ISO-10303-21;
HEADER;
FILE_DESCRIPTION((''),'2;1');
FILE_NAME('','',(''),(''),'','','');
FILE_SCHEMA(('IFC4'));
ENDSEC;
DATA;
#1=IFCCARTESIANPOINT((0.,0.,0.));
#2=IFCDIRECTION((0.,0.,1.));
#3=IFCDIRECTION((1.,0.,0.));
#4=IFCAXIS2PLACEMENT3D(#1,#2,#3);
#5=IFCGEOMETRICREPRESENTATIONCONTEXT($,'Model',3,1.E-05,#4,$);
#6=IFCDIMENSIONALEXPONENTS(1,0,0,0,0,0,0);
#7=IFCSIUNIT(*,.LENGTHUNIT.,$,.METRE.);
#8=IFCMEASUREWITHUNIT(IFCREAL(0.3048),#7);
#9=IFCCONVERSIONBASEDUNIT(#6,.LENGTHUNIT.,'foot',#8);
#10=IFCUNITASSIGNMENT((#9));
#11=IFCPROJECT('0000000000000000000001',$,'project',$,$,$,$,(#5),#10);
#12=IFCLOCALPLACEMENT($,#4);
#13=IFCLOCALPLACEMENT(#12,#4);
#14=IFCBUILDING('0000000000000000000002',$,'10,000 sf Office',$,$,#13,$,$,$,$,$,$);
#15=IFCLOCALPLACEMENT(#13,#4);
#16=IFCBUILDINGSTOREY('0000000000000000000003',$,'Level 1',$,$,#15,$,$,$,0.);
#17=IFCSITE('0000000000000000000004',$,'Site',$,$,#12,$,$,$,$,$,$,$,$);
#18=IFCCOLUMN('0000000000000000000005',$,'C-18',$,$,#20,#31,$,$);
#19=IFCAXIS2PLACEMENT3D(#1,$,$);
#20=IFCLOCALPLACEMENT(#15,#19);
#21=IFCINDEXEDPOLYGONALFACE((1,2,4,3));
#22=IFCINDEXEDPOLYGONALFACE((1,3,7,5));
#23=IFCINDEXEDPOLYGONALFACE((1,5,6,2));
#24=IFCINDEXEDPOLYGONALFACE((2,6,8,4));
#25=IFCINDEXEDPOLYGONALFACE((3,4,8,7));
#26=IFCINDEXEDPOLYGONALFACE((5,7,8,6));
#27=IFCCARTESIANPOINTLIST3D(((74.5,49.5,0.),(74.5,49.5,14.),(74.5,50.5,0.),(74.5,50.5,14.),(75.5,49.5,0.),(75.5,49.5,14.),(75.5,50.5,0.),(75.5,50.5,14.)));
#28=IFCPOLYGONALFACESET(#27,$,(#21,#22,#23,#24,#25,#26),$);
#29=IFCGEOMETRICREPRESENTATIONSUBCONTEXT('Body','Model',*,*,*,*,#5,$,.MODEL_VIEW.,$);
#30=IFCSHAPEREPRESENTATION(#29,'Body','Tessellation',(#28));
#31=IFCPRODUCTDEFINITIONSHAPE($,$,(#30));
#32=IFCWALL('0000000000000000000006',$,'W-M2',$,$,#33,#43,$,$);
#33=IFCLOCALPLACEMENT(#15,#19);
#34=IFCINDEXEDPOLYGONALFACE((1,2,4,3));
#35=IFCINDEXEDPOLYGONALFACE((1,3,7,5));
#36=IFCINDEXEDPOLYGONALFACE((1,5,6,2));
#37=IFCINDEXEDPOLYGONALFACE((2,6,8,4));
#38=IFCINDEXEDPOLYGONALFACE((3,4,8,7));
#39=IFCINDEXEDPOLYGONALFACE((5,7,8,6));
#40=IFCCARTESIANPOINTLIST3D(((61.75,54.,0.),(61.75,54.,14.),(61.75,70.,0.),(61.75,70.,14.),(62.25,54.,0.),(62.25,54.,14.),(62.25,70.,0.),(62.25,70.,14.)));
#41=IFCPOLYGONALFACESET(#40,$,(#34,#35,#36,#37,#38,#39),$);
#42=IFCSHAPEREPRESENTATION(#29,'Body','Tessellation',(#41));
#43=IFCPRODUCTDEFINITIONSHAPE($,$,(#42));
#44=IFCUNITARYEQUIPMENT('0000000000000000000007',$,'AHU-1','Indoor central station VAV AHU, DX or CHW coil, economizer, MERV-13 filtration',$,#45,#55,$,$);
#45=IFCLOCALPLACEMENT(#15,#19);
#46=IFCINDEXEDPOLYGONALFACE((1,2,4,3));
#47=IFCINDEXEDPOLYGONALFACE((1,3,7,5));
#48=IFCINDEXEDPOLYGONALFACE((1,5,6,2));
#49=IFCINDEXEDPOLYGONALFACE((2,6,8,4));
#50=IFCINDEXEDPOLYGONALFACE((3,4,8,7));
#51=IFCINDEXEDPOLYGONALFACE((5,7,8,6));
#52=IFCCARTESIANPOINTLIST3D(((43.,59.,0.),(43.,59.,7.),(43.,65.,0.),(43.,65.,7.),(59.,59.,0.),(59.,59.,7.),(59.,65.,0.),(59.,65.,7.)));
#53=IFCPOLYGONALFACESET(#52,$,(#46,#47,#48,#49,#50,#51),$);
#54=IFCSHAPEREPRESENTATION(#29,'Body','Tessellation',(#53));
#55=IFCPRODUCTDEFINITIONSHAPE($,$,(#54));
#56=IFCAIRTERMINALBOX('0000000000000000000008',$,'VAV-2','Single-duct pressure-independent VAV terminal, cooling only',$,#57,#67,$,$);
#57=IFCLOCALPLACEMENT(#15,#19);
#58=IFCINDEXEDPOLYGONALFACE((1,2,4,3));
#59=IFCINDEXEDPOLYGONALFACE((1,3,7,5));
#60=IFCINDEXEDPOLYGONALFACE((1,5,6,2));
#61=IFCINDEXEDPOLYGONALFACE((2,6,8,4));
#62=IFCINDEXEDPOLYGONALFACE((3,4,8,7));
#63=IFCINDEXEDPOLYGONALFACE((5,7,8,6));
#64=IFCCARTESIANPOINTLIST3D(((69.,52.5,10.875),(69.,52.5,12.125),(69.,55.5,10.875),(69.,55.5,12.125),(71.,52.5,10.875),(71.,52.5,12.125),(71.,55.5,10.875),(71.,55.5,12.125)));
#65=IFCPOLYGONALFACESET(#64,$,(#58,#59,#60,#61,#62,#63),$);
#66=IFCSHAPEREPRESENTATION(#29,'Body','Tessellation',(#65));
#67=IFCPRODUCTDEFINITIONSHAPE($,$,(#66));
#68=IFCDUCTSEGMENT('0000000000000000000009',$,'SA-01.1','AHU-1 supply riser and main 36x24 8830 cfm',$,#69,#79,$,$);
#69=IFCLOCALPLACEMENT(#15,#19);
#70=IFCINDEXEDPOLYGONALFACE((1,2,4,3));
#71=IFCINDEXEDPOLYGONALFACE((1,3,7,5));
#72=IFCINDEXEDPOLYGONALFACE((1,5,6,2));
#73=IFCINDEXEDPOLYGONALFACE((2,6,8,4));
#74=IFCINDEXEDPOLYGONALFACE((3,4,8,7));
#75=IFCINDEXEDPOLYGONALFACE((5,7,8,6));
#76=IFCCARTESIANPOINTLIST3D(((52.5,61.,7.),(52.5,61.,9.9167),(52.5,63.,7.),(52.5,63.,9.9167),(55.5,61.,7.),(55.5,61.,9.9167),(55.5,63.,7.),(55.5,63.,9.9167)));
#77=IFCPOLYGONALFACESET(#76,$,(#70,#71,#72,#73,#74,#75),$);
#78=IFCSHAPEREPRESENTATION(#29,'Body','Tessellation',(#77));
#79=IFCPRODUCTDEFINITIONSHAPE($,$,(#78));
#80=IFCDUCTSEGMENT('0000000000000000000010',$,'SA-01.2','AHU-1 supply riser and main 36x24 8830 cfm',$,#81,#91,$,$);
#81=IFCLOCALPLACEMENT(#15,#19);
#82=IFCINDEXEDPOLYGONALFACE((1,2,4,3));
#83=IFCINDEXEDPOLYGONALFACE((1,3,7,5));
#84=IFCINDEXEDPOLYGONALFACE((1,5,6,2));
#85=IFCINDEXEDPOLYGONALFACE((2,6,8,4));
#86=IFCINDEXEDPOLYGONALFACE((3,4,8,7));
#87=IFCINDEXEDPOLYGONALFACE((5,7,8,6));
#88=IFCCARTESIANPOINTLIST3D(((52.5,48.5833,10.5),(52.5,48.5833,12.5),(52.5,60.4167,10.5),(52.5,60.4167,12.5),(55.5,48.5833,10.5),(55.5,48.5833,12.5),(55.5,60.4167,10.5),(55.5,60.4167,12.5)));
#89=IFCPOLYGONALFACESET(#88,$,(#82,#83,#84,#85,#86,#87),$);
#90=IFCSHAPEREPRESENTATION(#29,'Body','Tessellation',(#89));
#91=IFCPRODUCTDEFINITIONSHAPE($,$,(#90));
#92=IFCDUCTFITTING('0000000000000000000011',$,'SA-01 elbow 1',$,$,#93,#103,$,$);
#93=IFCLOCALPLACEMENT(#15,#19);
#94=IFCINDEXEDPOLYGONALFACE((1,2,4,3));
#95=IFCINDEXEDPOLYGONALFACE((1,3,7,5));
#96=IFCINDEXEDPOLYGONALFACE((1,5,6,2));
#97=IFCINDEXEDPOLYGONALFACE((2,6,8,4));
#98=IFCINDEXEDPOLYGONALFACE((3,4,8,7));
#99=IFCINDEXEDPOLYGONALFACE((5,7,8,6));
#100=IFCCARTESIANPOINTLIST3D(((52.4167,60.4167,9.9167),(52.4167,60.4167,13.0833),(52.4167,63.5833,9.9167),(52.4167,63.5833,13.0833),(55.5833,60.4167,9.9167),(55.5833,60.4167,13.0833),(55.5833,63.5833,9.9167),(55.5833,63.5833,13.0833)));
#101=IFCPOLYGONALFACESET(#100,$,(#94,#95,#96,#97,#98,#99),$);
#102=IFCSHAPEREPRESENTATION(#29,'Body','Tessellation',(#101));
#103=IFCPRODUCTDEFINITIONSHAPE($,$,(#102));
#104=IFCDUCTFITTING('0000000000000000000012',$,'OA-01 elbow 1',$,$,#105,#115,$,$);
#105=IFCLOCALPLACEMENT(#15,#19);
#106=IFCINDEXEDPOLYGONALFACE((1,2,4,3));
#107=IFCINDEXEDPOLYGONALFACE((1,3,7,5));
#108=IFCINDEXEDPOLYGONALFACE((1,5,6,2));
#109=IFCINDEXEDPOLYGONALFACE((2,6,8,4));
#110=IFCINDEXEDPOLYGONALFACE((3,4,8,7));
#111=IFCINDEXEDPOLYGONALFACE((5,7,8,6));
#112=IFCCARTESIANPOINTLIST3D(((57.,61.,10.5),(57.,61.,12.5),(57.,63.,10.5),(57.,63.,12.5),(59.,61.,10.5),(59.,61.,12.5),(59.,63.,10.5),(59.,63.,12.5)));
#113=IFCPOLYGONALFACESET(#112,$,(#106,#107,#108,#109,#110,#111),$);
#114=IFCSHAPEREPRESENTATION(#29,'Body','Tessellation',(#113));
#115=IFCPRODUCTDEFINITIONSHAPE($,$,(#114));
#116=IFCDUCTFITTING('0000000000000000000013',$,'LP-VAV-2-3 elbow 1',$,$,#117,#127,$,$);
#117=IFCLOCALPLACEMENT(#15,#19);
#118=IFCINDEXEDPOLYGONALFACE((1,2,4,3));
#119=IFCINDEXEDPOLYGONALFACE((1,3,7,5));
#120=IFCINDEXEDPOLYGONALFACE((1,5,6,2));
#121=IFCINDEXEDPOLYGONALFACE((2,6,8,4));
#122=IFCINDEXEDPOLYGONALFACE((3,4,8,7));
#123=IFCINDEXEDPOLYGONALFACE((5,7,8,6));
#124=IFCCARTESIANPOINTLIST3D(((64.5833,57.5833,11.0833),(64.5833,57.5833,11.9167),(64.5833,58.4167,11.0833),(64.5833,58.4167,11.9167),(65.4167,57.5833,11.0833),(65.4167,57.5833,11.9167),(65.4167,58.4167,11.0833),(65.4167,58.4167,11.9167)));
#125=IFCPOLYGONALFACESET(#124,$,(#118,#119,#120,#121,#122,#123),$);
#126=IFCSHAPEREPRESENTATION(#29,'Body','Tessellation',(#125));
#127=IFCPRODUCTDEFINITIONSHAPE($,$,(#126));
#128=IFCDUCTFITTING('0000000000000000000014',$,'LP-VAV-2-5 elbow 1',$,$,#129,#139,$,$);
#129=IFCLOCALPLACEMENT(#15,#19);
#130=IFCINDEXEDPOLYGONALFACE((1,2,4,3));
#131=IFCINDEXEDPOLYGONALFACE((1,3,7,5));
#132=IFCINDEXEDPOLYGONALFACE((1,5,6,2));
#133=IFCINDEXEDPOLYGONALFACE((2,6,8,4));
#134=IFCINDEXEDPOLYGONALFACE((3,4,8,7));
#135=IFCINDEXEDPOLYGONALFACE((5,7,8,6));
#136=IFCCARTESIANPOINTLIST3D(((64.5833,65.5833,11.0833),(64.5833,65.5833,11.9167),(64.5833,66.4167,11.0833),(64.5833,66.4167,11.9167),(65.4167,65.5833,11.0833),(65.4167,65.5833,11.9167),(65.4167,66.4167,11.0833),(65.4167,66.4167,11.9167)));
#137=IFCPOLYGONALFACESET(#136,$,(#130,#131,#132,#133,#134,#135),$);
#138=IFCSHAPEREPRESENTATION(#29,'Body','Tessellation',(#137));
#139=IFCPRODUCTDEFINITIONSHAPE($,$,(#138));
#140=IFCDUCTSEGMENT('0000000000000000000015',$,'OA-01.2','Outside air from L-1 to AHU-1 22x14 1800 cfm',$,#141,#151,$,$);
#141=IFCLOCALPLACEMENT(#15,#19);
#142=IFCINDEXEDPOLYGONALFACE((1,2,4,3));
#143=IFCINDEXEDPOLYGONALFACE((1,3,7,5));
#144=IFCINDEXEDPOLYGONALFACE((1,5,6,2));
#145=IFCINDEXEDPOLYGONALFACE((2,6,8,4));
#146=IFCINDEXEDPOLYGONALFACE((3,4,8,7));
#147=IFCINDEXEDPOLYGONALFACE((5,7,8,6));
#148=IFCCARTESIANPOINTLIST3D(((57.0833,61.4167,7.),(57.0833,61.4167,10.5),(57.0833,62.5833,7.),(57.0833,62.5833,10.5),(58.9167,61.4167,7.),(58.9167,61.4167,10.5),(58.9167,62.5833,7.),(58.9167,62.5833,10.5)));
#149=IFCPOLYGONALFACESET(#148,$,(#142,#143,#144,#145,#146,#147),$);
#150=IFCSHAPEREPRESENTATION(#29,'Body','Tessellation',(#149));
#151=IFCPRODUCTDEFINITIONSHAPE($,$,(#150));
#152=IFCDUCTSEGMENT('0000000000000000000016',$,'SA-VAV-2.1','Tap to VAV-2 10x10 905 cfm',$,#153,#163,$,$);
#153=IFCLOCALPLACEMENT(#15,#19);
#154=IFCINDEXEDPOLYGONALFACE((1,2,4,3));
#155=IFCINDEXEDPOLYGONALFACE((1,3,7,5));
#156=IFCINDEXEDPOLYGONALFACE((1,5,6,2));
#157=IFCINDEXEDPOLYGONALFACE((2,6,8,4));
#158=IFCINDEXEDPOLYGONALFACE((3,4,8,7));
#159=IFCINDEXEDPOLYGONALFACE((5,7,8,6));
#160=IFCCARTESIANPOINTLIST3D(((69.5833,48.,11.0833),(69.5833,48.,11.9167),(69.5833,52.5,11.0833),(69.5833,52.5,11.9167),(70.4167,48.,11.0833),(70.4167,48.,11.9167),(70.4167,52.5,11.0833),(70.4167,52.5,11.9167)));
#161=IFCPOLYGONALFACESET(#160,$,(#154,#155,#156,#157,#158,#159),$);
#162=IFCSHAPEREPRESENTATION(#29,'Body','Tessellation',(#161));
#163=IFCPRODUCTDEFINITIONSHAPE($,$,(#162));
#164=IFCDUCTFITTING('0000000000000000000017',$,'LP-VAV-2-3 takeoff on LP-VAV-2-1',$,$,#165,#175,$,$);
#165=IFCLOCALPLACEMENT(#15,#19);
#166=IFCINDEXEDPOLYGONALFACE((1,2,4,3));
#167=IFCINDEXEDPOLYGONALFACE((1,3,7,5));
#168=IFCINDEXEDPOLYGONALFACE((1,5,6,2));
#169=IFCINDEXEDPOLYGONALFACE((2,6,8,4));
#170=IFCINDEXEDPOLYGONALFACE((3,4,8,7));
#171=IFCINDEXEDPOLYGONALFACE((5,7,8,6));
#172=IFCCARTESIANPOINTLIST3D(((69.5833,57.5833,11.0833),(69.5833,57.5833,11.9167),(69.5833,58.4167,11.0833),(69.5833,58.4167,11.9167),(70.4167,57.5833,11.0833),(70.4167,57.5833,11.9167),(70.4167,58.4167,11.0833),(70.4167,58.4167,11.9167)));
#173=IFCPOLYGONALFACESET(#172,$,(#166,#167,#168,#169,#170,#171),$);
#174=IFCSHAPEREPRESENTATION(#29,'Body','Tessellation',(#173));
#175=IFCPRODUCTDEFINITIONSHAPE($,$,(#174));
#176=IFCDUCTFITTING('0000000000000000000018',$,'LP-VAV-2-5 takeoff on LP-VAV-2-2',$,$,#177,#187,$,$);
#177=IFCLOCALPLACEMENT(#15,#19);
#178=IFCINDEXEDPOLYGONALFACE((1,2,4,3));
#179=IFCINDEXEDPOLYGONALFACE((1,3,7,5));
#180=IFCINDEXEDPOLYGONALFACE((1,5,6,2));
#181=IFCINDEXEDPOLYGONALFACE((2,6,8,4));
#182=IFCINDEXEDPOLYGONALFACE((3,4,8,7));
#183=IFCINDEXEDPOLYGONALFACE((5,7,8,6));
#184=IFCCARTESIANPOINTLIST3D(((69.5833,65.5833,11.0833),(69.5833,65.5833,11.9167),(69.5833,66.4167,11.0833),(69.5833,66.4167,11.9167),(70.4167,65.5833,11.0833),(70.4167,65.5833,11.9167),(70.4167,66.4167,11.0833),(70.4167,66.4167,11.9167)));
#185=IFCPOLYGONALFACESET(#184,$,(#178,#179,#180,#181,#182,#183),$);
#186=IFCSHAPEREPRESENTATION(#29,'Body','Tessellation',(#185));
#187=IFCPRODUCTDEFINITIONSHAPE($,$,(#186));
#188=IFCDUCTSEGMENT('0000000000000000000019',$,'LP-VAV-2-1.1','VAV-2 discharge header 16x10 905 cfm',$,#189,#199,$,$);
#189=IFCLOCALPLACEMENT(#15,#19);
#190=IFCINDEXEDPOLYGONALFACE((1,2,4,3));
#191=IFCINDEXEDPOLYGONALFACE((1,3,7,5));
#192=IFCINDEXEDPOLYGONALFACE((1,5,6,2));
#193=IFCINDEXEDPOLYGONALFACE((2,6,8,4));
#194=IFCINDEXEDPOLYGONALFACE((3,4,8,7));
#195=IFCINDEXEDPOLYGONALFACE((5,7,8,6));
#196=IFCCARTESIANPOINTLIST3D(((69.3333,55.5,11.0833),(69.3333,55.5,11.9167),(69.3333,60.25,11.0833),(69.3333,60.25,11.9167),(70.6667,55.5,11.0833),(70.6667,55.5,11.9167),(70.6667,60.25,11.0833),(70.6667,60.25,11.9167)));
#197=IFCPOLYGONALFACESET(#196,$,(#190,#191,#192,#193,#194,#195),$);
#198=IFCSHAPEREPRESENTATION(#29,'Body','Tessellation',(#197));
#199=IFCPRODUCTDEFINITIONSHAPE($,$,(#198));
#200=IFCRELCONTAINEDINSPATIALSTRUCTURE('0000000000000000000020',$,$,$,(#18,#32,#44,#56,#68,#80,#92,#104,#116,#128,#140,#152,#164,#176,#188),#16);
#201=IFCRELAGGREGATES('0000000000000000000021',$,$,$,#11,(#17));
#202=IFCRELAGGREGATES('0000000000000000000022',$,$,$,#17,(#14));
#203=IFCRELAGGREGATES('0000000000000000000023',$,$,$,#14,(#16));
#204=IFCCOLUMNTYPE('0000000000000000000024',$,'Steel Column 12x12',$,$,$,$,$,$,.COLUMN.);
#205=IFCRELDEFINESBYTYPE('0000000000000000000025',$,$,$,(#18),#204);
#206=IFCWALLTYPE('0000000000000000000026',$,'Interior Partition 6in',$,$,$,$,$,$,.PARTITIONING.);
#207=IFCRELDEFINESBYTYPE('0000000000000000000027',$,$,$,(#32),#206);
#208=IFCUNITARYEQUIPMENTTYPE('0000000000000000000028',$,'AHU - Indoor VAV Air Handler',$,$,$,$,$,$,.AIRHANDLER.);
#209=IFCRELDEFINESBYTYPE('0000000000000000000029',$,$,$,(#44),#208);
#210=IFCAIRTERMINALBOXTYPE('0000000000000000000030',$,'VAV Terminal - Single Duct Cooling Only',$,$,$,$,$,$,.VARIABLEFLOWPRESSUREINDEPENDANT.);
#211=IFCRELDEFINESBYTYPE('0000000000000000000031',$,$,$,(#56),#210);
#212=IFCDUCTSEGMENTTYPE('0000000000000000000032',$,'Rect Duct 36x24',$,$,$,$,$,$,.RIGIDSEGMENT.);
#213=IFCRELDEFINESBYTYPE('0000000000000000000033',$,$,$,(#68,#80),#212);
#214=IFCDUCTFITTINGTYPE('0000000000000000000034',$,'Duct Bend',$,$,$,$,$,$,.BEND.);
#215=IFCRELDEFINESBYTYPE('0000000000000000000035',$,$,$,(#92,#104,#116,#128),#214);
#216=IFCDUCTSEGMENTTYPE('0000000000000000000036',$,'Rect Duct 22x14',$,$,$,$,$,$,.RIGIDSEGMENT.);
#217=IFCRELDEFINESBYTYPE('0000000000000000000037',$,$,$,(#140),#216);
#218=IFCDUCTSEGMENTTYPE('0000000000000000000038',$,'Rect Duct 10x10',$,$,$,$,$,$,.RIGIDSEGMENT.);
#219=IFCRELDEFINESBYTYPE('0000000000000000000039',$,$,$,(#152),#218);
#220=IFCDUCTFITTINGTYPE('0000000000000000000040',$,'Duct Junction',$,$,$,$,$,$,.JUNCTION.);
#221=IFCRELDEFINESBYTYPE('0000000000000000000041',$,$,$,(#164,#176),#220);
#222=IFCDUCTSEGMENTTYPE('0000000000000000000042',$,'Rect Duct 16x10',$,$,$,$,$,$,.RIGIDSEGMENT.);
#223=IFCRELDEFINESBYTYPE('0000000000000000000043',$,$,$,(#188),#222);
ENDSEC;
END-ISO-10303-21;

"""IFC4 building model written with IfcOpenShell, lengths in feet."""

from ifc_helpers import new_model, entity, si_unit, converted_unit, frame, origin_with_axes, place, context, subcontext, project, spatial, rectangle, extrude, type_object, element, save


model = new_model("IFC4")

# Units and contexts
model_context = context("Model", 3, precision=1e-05, world=origin_with_axes())
body_context = subcontext(model_context, "Body", "Model", "MODEL_VIEW")
ifc_project = project(units=[converted_unit("LENGTHUNIT", "foot", entity("IfcReal", 0.3048), si_unit("LENGTHUNIT", "METRE"), dimensions=[1, 0, 0, 0, 0, 0, 0])], contexts=[model_context])

# Site, building, storey
site_placement = place(None, origin_with_axes())
site = spatial("IfcSite", under=ifc_project, at=site_placement, Name="Site")
building_placement = place(site_placement, origin_with_axes())
building = spatial("IfcBuilding", under=site, at=building_placement, Name="10,000 sf Office")
storey_placement = place(building_placement, origin_with_axes())
storey = spatial("IfcBuildingStorey", under=building, at=storey_placement, Name="Level 1", Elevation=0.0)

# Column
column_type = type_object("IfcColumnType", Name="Steel Column 12x12", PredefinedType="COLUMN")
column_placement = place(storey_placement, frame((75.0, 50.0, 0.0), z_axis=(0.0, 0.0, 1.0), x_axis=(1.0, 0.0, 0.0)))
element("IfcColumn", 1, at=column_placement, inside=storey, type_object=column_type, Name="C-18", context=body_context, shape_type="SweptSolid", body=[
    extrude(rectangle(XDim=1.0, YDim=1.0), None, (0.0, 0.0, 1.0), 14.0),
])

# Wall
wall_type = type_object("IfcWallType", Name="Interior Partition 6in", PredefinedType="PARTITIONING")
wall_placement = place(storey_placement, frame((62.0, 62.0, 0.0), z_axis=(0.0, 0.0, 1.0), x_axis=(0.0, 1.0, 0.0)))
element("IfcWall", 2, at=wall_placement, inside=storey, type_object=wall_type, Name="W-M2", context=body_context, shape_type="SweptSolid", body=[
    extrude(rectangle(XDim=16.0, YDim=0.5), None, (0.0, 0.0, 1.0), 14.0),
])

# Unitary equipment
unitary_equipment_type = type_object("IfcUnitaryEquipmentType", Name="AHU - Indoor VAV Air Handler", PredefinedType="AIRHANDLER")
unitary_equipment_placement = place(storey_placement, frame((51.0, 62.0, 0.0), z_axis=(0.0, 0.0, 1.0), x_axis=(1.0, 0.0, 0.0)))
element("IfcUnitaryEquipment", 3, at=unitary_equipment_placement, inside=storey, type_object=unitary_equipment_type, Name="AHU-1", Description="Indoor central station VAV AHU, DX or CHW coil, economizer, MERV-13 filtration", context=body_context, shape_type="SweptSolid", body=[
    extrude(rectangle(XDim=16.0, YDim=6.0), None, (0.0, 0.0, 1.0), 7.0),
])

# Air terminal box
air_terminal_box_type = type_object("IfcAirTerminalBoxType", Name="VAV Terminal - Single Duct Cooling Only", PredefinedType="VARIABLEFLOWPRESSUREINDEPENDANT")
air_terminal_box_placement = place(storey_placement, frame((70.0, 54.0, 10.875), z_axis=(0.0, 0.0, 1.0), x_axis=(0.0, 1.0, 0.0)))
element("IfcAirTerminalBox", 4, at=air_terminal_box_placement, inside=storey, type_object=air_terminal_box_type, Name="VAV-2", Description="Single-duct pressure-independent VAV terminal, cooling only", context=body_context, shape_type="SweptSolid", body=[
    extrude(rectangle(XDim=3.0, YDim=2.0), None, (0.0, 0.0, 1.0), 1.25),
])

# Duct segments
duct_segment_type_1 = type_object("IfcDuctSegmentType", Name="Rect Duct 36x24", PredefinedType="RIGIDSEGMENT")
duct_segment_1_placement = place(storey_placement, frame((54.0, 62.0, 7.0), z_axis=(0.0, 0.0, 1.0), x_axis=(1.0, 0.0, 0.0)))
element("IfcDuctSegment", 5, at=duct_segment_1_placement, inside=storey, type_object=duct_segment_type_1, Name="SA-01.1", Description="AHU-1 supply riser and main 36x24 8830 cfm", context=body_context, shape_type="SweptSolid", body=[
    extrude(rectangle(XDim=3.0, YDim=2.0), None, (0.0, 0.0, 1.0), 2.9167),
])
duct_segment_2_placement = place(storey_placement, frame((54.0, 60.4167, 11.5), z_axis=(0.0, -1.0, 0.0), x_axis=(1.0, 0.0, 0.0)))
element("IfcDuctSegment", 6, at=duct_segment_2_placement, inside=storey, type_object=duct_segment_type_1, Name="SA-01.2", Description="AHU-1 supply riser and main 36x24 8830 cfm", context=body_context, shape_type="SweptSolid", body=[
    extrude(rectangle(XDim=3.0, YDim=2.0), None, (0.0, 0.0, 1.0), 11.8333),
])

# Duct fittings
duct_fitting_type_1 = type_object("IfcDuctFittingType", Name="Duct Bend", PredefinedType="BEND")
duct_fitting_1_placement = place(storey_placement, frame((54.0, 62.0, 9.9167), z_axis=(0.0, 0.0, 1.0), x_axis=(1.0, 0.0, 0.0)))
element("IfcDuctFitting", 7, at=duct_fitting_1_placement, inside=storey, type_object=duct_fitting_type_1, Name="SA-01 elbow 1", context=body_context, shape_type="SweptSolid", body=[
    extrude(rectangle(XDim=3.1667, YDim=3.1667), None, (0.0, 0.0, 1.0), 3.1667),
])
duct_fitting_2_placement = place(storey_placement, frame((58.0, 62.0, 10.5), z_axis=(0.0, 0.0, 1.0), x_axis=(1.0, 0.0, 0.0)))
element("IfcDuctFitting", 8, at=duct_fitting_2_placement, inside=storey, type_object=duct_fitting_type_1, Name="OA-01 elbow 1", context=body_context, shape_type="SweptSolid", body=[
    extrude(rectangle(XDim=2.0, YDim=2.0), None, (0.0, 0.0, 1.0), 2.0),
])
for number, where, z_axis, x_axis, name in (
    (9, (65.0, 58.0, 11.0833), (0.0, 0.0, 1.0), (1.0, 0.0, 0.0), "LP-VAV-2-3 elbow 1"),
    (10, (65.0, 66.0, 11.0833), (0.0, 0.0, 1.0), (1.0, 0.0, 0.0), "LP-VAV-2-5 elbow 1"),
):
    element("IfcDuctFitting", number, at=place(storey_placement, frame(where, z_axis=z_axis, x_axis=x_axis)), inside=storey, type_object=duct_fitting_type_1, Name=name, context=body_context, shape_type="SweptSolid", body=[
        extrude(rectangle(XDim=0.8333, YDim=0.8333), None, (0.0, 0.0, 1.0), 0.8333),
    ])

# Duct segments
duct_segment_type_2 = type_object("IfcDuctSegmentType", Name="Rect Duct 22x14", PredefinedType="RIGIDSEGMENT")
duct_segment_3_placement = place(storey_placement, frame((58.0, 62.0, 10.5), z_axis=(0.0, 0.0, -1.0), x_axis=(1.0, 0.0, 0.0)))
element("IfcDuctSegment", 11, at=duct_segment_3_placement, inside=storey, type_object=duct_segment_type_2, Name="OA-01.2", Description="Outside air from L-1 to AHU-1 22x14 1800 cfm", context=body_context, shape_type="SweptSolid", body=[
    extrude(rectangle(XDim=1.8333, YDim=1.1667), None, (0.0, 0.0, 1.0), 3.5),
])
duct_segment_type_3 = type_object("IfcDuctSegmentType", Name="Rect Duct 10x10", PredefinedType="RIGIDSEGMENT")
duct_segment_4_placement = place(storey_placement, frame((70.0, 48.0, 11.5), z_axis=(0.0, 1.0, 0.0), x_axis=(-1.0, 0.0, 0.0)))
element("IfcDuctSegment", 12, at=duct_segment_4_placement, inside=storey, type_object=duct_segment_type_3, Name="SA-VAV-2.1", Description="Tap to VAV-2 10x10 905 cfm", context=body_context, shape_type="SweptSolid", body=[
    extrude(rectangle(XDim=0.8333, YDim=0.8333), None, (0.0, 0.0, 1.0), 4.5),
])

# Duct fittings
duct_fitting_type_2 = type_object("IfcDuctFittingType", Name="Duct Junction", PredefinedType="JUNCTION")
for number, where, z_axis, x_axis, name in (
    (13, (70.0, 58.0, 11.0833), (0.0, 0.0, 1.0), (1.0, 0.0, 0.0), "LP-VAV-2-3 takeoff on LP-VAV-2-1"),
    (14, (70.0, 66.0, 11.0833), (0.0, 0.0, 1.0), (1.0, 0.0, 0.0), "LP-VAV-2-5 takeoff on LP-VAV-2-2"),
):
    element("IfcDuctFitting", number, at=place(storey_placement, frame(where, z_axis=z_axis, x_axis=x_axis)), inside=storey, type_object=duct_fitting_type_2, Name=name, context=body_context, shape_type="SweptSolid", body=[
        extrude(rectangle(XDim=0.8333, YDim=0.8333), None, (0.0, 0.0, 1.0), 0.8333),
    ])

# Duct segment
duct_segment_type_4 = type_object("IfcDuctSegmentType", Name="Rect Duct 16x10", PredefinedType="RIGIDSEGMENT")
duct_segment_5_placement = place(storey_placement, frame((70.0, 55.5, 11.5), z_axis=(0.0, 1.0, 0.0), x_axis=(-1.0, 0.0, 0.0)))
element("IfcDuctSegment", 15, at=duct_segment_5_placement, inside=storey, type_object=duct_segment_type_4, Name="LP-VAV-2-1.1", Description="VAV-2 discharge header 16x10 905 cfm", context=body_context, shape_type="SweptSolid", body=[
    extrude(rectangle(XDim=1.3333, YDim=0.8333), None, (0.0, 0.0, 1.0), 4.75),
])

save(model, "model.ifc")
